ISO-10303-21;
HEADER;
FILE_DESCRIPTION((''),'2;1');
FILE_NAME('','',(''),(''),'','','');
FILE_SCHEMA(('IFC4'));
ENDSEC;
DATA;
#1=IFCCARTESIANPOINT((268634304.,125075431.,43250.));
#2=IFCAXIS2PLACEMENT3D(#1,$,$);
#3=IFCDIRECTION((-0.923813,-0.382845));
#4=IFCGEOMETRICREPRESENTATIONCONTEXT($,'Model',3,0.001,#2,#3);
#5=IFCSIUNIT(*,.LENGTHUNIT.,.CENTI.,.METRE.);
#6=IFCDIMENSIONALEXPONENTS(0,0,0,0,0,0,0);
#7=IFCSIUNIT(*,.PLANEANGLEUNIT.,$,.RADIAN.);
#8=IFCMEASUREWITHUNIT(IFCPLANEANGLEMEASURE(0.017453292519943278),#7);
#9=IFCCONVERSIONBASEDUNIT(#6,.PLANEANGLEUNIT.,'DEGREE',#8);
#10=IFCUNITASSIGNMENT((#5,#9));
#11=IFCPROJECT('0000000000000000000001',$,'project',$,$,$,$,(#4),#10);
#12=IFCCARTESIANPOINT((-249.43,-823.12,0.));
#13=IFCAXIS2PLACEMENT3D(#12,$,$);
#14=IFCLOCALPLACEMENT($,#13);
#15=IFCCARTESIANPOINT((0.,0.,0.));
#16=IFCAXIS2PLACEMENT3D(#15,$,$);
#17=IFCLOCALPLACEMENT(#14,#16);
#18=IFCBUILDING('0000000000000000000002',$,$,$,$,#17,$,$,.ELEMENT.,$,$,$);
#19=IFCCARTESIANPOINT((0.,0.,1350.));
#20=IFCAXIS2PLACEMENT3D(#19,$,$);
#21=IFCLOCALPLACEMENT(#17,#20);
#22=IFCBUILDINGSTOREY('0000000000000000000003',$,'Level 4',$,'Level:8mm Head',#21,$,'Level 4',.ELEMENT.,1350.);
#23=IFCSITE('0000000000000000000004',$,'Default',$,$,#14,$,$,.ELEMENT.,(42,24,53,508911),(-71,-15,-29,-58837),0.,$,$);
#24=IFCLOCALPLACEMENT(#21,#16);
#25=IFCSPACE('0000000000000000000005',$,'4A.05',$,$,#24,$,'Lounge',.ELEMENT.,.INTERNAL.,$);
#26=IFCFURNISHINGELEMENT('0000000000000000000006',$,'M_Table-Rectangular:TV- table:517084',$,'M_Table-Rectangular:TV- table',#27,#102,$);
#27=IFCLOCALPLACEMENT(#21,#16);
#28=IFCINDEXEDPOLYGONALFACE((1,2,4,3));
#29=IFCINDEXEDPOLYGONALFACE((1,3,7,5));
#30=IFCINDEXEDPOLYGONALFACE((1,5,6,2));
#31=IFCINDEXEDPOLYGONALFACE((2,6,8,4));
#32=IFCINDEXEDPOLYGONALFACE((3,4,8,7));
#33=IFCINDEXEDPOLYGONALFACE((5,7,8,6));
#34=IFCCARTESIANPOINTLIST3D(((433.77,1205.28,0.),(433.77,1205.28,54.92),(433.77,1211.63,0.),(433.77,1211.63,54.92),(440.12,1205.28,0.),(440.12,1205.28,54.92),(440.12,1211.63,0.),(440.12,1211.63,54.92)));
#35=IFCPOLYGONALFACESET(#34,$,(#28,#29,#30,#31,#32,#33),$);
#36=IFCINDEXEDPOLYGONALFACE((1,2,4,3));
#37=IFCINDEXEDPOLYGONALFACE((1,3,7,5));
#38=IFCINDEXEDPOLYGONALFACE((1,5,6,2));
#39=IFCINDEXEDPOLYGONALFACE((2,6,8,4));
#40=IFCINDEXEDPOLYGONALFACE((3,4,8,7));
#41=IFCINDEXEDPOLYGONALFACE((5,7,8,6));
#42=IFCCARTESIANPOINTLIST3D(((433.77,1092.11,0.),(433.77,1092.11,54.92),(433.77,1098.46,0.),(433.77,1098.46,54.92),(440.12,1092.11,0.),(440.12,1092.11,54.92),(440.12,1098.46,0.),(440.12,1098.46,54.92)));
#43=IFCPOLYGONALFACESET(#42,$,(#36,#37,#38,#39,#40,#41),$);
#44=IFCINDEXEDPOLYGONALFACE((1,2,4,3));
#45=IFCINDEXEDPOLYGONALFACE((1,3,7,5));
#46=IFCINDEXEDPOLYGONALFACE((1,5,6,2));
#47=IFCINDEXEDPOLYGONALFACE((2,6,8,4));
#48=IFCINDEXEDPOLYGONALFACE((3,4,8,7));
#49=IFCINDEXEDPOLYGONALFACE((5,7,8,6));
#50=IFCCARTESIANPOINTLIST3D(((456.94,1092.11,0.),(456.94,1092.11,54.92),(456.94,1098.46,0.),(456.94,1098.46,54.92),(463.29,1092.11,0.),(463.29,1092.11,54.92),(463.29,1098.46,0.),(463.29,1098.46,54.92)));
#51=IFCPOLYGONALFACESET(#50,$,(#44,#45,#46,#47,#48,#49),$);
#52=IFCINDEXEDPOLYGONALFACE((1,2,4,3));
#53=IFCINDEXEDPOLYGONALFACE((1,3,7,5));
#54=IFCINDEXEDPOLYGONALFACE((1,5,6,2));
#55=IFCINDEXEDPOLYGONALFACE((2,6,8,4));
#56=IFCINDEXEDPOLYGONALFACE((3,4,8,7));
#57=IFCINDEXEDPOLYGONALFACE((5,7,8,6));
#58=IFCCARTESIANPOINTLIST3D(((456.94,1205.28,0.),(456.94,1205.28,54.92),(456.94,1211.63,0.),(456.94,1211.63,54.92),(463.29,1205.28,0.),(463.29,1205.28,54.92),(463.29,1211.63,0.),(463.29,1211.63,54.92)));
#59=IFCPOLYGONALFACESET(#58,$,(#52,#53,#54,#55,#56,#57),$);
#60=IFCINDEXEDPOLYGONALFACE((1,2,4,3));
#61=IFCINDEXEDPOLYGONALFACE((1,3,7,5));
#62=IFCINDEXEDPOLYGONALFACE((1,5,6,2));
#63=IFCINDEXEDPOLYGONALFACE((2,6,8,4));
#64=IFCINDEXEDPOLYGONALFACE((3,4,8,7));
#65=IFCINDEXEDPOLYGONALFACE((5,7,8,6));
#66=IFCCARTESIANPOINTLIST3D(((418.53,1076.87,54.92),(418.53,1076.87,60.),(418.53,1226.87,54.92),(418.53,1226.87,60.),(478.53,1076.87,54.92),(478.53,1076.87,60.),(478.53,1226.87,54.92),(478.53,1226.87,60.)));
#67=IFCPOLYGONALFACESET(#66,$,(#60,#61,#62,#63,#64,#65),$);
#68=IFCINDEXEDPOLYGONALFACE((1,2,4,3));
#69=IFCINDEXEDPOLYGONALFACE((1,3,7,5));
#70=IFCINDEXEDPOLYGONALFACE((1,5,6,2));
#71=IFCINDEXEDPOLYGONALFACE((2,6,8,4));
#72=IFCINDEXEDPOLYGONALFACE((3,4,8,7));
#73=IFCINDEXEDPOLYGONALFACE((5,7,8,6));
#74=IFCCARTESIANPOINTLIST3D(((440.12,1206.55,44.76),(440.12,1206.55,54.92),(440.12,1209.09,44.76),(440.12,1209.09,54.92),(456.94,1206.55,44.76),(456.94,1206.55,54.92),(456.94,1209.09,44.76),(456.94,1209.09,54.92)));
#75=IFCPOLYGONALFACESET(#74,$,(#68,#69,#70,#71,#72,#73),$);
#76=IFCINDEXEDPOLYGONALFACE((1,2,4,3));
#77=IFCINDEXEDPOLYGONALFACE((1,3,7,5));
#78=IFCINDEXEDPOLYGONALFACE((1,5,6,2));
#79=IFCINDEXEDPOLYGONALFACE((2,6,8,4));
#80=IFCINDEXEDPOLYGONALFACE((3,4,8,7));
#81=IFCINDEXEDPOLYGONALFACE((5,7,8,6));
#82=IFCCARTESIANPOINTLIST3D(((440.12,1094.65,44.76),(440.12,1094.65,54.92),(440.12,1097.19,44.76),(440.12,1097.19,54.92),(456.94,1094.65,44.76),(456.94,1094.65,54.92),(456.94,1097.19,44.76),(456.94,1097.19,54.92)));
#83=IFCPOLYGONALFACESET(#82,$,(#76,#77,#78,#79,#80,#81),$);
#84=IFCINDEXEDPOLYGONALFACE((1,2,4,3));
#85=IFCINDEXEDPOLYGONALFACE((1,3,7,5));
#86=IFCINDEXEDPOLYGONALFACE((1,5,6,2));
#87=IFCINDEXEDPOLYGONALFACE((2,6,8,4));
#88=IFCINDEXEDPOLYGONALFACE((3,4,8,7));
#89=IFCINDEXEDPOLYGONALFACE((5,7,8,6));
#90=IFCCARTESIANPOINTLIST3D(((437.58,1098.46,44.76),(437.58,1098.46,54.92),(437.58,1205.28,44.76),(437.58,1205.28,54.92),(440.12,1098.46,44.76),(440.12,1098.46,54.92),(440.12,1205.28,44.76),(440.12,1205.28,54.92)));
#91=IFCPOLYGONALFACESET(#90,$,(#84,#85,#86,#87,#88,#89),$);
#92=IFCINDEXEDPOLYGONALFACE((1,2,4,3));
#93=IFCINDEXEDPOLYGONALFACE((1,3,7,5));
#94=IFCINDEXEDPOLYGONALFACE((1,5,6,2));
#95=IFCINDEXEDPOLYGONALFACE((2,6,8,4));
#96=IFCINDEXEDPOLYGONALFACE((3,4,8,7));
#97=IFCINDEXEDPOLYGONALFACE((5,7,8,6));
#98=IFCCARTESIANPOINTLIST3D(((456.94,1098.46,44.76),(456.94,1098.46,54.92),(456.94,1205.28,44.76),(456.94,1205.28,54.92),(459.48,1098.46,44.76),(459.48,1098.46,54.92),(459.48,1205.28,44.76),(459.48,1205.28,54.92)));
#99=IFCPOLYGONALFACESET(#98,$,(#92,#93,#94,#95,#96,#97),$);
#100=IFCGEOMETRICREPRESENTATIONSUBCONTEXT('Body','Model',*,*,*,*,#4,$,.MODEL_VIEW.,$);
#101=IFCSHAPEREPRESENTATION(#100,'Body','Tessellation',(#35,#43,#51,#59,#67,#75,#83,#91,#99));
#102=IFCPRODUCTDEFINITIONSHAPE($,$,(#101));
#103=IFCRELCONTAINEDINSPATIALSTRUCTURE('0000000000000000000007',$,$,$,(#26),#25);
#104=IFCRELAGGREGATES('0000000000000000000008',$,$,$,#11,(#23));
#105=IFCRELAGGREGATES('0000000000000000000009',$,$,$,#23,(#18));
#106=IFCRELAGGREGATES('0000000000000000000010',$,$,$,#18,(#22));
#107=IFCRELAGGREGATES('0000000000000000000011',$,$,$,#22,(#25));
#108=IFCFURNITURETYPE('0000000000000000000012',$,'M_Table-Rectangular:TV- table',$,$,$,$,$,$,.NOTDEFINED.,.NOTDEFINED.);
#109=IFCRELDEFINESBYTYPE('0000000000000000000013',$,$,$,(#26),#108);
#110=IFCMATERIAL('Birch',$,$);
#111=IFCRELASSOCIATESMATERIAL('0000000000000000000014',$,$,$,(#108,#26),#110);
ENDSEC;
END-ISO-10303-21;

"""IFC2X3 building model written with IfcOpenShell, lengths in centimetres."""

from ifc_helpers import new_model, entity, si_unit, converted_unit, direction, frame, frame_2d, origin, origin_2d_with_axis, place, context, subcontext, project, spatial, rectangle, extrude, source, transform, mapped, material, type_object, type_shapes, element, save


model = new_model("IFC2X3")

# Units and contexts
model_context = context("Model", 3, precision=0.001, world=frame((268634304.0, 125075431.0, 43250.0)), true_north=direction((-0.923813, -0.382845)))
body_context = subcontext(model_context, "Body", "Model", "MODEL_VIEW")
ifc_project = project(units=[si_unit("LENGTHUNIT", "METRE", prefix="CENTI"), converted_unit("PLANEANGLEUNIT", "DEGREE", entity("IfcPlaneAngleMeasure", 0.017453292519943278), si_unit("PLANEANGLEUNIT", "RADIAN"), dimensions=[0, 0, 0, 0, 0, 0, 0])], contexts=[model_context])

# Site, building, storey
site_placement = place(None, frame((-249.43, -823.12, 0.0)))
site = spatial("IfcSite", under=ifc_project, at=site_placement, Name="Default", CompositionType="ELEMENT", RefLatitude=(42, 24, 53, 508911), RefLongitude=(-71, -15, -29, -58837), RefElevation=0.0)
building_placement = place(site_placement, origin())
building = spatial("IfcBuilding", under=site, at=building_placement, CompositionType="ELEMENT")
storey_placement = place(building_placement, frame((0.0, 0.0, 1350.0)))
storey = spatial("IfcBuildingStorey", under=building, at=storey_placement, Name="Level 4", ObjectType="Level:8mm Head", LongName="Level 4", CompositionType="ELEMENT", Elevation=1350.0)

# Shared definitions
space_1_placement = place(storey_placement, origin())
space_1 = spatial("IfcSpace", under=storey, at=space_1_placement, Name="4A.05", LongName="Lounge", CompositionType="ELEMENT", InteriorOrExteriorSpace="INTERNAL")

# Furnishing element
ifc_material_1 = material(Name="Birch")
furniture_type_1 = type_object("IfcFurnitureType", Name="M_Table-Rectangular:TV- table", AssemblyPlace="NOTDEFINED", material=ifc_material_1)
shared_shape_1 = source(origin(), body_context, "Body", "SweptSolid", [
    extrude(rectangle(XDim=6.35, YDim=6.35, at=origin_2d_with_axis()), frame((56.58, 11.59, 0.0), z_axis=(0.0, 0.0, 1.0), x_axis=(0.0, -1.0, 0.0)), (0.0, 0.0, 1.0), 54.92),
    extrude(rectangle(XDim=6.35, YDim=6.35, at=frame_2d((0.0, 0.0), x_axis=(1.0, 0.0))), frame((-56.58, 11.59, 0.0), z_axis=(0.0, 0.0, 1.0), x_axis=(-1.0, 0.0, 0.0)), (0.0, 0.0, 1.0), 54.92),
    extrude(rectangle(XDim=6.35, YDim=6.35, at=origin_2d_with_axis()), frame((-56.58, -11.59, 0.0), z_axis=(0.0, 0.0, 1.0), x_axis=(0.0, 1.0, 0.0)), (0.0, 0.0, 1.0), 54.92),
    extrude(rectangle(XDim=6.35, YDim=6.35, at=origin_2d_with_axis()), frame((56.58, -11.59, 0.0)), (0.0, 0.0, 1.0), 54.92),
    extrude(rectangle(XDim=150.0, YDim=60.0, at=origin_2d_with_axis()), frame((0.0, 0.0, 54.92), z_axis=(0.0, 0.0, 1.0), x_axis=(-1.0, 0.0, 0.0)), (0.0, 0.0, 1.0), 5.08),
    extrude(rectangle(XDim=2.54, YDim=16.82, at=origin_2d_with_axis()), frame((55.95, 0.0, 44.76)), (0.0, 0.0, 1.0), 10.16),
    extrude(rectangle(XDim=16.82, YDim=2.54, at=origin_2d_with_axis()), frame((-55.95, 0.0, 44.76), z_axis=(0.0, 0.0, 1.0), x_axis=(0.0, 1.0, 0.0)), (0.0, 0.0, 1.0), 10.16),
    extrude(rectangle(XDim=106.82, YDim=2.54, at=frame_2d((0.0, 0.0), x_axis=(1.0, 0.0))), frame((0.0, 9.68, 44.76), z_axis=(0.0, 0.0, 1.0), x_axis=(-1.0, 0.0, 0.0)), (0.0, 0.0, 1.0), 10.16),
    extrude(rectangle(XDim=2.54, YDim=106.82, at=origin_2d_with_axis()), frame((0.0, -9.68, 44.76), z_axis=(0.0, 0.0, 1.0), x_axis=(0.0, 1.0, 0.0)), (0.0, 0.0, 1.0), 10.16),
])
type_shapes(furniture_type_1, [shared_shape_1])
furnishing_1_placement = place(space_1_placement, frame((448.53, 1151.87, 0.0), z_axis=(0.0, 0.0, 1.0), x_axis=(0.0, 1.0, 0.0)))
element("IfcFurnishingElement", 1, at=furnishing_1_placement, inside=space_1, type_object=furniture_type_1, material=ifc_material_1, Name="M_Table-Rectangular:TV- table:517084", ObjectType="M_Table-Rectangular:TV- table", context=body_context, shape_type="MappedRepresentation", body=[
    mapped(shared_shape_1, transform((0.0, 0.0, 0.0), scale=1.0)),
])

save(model, "model.ifc")
